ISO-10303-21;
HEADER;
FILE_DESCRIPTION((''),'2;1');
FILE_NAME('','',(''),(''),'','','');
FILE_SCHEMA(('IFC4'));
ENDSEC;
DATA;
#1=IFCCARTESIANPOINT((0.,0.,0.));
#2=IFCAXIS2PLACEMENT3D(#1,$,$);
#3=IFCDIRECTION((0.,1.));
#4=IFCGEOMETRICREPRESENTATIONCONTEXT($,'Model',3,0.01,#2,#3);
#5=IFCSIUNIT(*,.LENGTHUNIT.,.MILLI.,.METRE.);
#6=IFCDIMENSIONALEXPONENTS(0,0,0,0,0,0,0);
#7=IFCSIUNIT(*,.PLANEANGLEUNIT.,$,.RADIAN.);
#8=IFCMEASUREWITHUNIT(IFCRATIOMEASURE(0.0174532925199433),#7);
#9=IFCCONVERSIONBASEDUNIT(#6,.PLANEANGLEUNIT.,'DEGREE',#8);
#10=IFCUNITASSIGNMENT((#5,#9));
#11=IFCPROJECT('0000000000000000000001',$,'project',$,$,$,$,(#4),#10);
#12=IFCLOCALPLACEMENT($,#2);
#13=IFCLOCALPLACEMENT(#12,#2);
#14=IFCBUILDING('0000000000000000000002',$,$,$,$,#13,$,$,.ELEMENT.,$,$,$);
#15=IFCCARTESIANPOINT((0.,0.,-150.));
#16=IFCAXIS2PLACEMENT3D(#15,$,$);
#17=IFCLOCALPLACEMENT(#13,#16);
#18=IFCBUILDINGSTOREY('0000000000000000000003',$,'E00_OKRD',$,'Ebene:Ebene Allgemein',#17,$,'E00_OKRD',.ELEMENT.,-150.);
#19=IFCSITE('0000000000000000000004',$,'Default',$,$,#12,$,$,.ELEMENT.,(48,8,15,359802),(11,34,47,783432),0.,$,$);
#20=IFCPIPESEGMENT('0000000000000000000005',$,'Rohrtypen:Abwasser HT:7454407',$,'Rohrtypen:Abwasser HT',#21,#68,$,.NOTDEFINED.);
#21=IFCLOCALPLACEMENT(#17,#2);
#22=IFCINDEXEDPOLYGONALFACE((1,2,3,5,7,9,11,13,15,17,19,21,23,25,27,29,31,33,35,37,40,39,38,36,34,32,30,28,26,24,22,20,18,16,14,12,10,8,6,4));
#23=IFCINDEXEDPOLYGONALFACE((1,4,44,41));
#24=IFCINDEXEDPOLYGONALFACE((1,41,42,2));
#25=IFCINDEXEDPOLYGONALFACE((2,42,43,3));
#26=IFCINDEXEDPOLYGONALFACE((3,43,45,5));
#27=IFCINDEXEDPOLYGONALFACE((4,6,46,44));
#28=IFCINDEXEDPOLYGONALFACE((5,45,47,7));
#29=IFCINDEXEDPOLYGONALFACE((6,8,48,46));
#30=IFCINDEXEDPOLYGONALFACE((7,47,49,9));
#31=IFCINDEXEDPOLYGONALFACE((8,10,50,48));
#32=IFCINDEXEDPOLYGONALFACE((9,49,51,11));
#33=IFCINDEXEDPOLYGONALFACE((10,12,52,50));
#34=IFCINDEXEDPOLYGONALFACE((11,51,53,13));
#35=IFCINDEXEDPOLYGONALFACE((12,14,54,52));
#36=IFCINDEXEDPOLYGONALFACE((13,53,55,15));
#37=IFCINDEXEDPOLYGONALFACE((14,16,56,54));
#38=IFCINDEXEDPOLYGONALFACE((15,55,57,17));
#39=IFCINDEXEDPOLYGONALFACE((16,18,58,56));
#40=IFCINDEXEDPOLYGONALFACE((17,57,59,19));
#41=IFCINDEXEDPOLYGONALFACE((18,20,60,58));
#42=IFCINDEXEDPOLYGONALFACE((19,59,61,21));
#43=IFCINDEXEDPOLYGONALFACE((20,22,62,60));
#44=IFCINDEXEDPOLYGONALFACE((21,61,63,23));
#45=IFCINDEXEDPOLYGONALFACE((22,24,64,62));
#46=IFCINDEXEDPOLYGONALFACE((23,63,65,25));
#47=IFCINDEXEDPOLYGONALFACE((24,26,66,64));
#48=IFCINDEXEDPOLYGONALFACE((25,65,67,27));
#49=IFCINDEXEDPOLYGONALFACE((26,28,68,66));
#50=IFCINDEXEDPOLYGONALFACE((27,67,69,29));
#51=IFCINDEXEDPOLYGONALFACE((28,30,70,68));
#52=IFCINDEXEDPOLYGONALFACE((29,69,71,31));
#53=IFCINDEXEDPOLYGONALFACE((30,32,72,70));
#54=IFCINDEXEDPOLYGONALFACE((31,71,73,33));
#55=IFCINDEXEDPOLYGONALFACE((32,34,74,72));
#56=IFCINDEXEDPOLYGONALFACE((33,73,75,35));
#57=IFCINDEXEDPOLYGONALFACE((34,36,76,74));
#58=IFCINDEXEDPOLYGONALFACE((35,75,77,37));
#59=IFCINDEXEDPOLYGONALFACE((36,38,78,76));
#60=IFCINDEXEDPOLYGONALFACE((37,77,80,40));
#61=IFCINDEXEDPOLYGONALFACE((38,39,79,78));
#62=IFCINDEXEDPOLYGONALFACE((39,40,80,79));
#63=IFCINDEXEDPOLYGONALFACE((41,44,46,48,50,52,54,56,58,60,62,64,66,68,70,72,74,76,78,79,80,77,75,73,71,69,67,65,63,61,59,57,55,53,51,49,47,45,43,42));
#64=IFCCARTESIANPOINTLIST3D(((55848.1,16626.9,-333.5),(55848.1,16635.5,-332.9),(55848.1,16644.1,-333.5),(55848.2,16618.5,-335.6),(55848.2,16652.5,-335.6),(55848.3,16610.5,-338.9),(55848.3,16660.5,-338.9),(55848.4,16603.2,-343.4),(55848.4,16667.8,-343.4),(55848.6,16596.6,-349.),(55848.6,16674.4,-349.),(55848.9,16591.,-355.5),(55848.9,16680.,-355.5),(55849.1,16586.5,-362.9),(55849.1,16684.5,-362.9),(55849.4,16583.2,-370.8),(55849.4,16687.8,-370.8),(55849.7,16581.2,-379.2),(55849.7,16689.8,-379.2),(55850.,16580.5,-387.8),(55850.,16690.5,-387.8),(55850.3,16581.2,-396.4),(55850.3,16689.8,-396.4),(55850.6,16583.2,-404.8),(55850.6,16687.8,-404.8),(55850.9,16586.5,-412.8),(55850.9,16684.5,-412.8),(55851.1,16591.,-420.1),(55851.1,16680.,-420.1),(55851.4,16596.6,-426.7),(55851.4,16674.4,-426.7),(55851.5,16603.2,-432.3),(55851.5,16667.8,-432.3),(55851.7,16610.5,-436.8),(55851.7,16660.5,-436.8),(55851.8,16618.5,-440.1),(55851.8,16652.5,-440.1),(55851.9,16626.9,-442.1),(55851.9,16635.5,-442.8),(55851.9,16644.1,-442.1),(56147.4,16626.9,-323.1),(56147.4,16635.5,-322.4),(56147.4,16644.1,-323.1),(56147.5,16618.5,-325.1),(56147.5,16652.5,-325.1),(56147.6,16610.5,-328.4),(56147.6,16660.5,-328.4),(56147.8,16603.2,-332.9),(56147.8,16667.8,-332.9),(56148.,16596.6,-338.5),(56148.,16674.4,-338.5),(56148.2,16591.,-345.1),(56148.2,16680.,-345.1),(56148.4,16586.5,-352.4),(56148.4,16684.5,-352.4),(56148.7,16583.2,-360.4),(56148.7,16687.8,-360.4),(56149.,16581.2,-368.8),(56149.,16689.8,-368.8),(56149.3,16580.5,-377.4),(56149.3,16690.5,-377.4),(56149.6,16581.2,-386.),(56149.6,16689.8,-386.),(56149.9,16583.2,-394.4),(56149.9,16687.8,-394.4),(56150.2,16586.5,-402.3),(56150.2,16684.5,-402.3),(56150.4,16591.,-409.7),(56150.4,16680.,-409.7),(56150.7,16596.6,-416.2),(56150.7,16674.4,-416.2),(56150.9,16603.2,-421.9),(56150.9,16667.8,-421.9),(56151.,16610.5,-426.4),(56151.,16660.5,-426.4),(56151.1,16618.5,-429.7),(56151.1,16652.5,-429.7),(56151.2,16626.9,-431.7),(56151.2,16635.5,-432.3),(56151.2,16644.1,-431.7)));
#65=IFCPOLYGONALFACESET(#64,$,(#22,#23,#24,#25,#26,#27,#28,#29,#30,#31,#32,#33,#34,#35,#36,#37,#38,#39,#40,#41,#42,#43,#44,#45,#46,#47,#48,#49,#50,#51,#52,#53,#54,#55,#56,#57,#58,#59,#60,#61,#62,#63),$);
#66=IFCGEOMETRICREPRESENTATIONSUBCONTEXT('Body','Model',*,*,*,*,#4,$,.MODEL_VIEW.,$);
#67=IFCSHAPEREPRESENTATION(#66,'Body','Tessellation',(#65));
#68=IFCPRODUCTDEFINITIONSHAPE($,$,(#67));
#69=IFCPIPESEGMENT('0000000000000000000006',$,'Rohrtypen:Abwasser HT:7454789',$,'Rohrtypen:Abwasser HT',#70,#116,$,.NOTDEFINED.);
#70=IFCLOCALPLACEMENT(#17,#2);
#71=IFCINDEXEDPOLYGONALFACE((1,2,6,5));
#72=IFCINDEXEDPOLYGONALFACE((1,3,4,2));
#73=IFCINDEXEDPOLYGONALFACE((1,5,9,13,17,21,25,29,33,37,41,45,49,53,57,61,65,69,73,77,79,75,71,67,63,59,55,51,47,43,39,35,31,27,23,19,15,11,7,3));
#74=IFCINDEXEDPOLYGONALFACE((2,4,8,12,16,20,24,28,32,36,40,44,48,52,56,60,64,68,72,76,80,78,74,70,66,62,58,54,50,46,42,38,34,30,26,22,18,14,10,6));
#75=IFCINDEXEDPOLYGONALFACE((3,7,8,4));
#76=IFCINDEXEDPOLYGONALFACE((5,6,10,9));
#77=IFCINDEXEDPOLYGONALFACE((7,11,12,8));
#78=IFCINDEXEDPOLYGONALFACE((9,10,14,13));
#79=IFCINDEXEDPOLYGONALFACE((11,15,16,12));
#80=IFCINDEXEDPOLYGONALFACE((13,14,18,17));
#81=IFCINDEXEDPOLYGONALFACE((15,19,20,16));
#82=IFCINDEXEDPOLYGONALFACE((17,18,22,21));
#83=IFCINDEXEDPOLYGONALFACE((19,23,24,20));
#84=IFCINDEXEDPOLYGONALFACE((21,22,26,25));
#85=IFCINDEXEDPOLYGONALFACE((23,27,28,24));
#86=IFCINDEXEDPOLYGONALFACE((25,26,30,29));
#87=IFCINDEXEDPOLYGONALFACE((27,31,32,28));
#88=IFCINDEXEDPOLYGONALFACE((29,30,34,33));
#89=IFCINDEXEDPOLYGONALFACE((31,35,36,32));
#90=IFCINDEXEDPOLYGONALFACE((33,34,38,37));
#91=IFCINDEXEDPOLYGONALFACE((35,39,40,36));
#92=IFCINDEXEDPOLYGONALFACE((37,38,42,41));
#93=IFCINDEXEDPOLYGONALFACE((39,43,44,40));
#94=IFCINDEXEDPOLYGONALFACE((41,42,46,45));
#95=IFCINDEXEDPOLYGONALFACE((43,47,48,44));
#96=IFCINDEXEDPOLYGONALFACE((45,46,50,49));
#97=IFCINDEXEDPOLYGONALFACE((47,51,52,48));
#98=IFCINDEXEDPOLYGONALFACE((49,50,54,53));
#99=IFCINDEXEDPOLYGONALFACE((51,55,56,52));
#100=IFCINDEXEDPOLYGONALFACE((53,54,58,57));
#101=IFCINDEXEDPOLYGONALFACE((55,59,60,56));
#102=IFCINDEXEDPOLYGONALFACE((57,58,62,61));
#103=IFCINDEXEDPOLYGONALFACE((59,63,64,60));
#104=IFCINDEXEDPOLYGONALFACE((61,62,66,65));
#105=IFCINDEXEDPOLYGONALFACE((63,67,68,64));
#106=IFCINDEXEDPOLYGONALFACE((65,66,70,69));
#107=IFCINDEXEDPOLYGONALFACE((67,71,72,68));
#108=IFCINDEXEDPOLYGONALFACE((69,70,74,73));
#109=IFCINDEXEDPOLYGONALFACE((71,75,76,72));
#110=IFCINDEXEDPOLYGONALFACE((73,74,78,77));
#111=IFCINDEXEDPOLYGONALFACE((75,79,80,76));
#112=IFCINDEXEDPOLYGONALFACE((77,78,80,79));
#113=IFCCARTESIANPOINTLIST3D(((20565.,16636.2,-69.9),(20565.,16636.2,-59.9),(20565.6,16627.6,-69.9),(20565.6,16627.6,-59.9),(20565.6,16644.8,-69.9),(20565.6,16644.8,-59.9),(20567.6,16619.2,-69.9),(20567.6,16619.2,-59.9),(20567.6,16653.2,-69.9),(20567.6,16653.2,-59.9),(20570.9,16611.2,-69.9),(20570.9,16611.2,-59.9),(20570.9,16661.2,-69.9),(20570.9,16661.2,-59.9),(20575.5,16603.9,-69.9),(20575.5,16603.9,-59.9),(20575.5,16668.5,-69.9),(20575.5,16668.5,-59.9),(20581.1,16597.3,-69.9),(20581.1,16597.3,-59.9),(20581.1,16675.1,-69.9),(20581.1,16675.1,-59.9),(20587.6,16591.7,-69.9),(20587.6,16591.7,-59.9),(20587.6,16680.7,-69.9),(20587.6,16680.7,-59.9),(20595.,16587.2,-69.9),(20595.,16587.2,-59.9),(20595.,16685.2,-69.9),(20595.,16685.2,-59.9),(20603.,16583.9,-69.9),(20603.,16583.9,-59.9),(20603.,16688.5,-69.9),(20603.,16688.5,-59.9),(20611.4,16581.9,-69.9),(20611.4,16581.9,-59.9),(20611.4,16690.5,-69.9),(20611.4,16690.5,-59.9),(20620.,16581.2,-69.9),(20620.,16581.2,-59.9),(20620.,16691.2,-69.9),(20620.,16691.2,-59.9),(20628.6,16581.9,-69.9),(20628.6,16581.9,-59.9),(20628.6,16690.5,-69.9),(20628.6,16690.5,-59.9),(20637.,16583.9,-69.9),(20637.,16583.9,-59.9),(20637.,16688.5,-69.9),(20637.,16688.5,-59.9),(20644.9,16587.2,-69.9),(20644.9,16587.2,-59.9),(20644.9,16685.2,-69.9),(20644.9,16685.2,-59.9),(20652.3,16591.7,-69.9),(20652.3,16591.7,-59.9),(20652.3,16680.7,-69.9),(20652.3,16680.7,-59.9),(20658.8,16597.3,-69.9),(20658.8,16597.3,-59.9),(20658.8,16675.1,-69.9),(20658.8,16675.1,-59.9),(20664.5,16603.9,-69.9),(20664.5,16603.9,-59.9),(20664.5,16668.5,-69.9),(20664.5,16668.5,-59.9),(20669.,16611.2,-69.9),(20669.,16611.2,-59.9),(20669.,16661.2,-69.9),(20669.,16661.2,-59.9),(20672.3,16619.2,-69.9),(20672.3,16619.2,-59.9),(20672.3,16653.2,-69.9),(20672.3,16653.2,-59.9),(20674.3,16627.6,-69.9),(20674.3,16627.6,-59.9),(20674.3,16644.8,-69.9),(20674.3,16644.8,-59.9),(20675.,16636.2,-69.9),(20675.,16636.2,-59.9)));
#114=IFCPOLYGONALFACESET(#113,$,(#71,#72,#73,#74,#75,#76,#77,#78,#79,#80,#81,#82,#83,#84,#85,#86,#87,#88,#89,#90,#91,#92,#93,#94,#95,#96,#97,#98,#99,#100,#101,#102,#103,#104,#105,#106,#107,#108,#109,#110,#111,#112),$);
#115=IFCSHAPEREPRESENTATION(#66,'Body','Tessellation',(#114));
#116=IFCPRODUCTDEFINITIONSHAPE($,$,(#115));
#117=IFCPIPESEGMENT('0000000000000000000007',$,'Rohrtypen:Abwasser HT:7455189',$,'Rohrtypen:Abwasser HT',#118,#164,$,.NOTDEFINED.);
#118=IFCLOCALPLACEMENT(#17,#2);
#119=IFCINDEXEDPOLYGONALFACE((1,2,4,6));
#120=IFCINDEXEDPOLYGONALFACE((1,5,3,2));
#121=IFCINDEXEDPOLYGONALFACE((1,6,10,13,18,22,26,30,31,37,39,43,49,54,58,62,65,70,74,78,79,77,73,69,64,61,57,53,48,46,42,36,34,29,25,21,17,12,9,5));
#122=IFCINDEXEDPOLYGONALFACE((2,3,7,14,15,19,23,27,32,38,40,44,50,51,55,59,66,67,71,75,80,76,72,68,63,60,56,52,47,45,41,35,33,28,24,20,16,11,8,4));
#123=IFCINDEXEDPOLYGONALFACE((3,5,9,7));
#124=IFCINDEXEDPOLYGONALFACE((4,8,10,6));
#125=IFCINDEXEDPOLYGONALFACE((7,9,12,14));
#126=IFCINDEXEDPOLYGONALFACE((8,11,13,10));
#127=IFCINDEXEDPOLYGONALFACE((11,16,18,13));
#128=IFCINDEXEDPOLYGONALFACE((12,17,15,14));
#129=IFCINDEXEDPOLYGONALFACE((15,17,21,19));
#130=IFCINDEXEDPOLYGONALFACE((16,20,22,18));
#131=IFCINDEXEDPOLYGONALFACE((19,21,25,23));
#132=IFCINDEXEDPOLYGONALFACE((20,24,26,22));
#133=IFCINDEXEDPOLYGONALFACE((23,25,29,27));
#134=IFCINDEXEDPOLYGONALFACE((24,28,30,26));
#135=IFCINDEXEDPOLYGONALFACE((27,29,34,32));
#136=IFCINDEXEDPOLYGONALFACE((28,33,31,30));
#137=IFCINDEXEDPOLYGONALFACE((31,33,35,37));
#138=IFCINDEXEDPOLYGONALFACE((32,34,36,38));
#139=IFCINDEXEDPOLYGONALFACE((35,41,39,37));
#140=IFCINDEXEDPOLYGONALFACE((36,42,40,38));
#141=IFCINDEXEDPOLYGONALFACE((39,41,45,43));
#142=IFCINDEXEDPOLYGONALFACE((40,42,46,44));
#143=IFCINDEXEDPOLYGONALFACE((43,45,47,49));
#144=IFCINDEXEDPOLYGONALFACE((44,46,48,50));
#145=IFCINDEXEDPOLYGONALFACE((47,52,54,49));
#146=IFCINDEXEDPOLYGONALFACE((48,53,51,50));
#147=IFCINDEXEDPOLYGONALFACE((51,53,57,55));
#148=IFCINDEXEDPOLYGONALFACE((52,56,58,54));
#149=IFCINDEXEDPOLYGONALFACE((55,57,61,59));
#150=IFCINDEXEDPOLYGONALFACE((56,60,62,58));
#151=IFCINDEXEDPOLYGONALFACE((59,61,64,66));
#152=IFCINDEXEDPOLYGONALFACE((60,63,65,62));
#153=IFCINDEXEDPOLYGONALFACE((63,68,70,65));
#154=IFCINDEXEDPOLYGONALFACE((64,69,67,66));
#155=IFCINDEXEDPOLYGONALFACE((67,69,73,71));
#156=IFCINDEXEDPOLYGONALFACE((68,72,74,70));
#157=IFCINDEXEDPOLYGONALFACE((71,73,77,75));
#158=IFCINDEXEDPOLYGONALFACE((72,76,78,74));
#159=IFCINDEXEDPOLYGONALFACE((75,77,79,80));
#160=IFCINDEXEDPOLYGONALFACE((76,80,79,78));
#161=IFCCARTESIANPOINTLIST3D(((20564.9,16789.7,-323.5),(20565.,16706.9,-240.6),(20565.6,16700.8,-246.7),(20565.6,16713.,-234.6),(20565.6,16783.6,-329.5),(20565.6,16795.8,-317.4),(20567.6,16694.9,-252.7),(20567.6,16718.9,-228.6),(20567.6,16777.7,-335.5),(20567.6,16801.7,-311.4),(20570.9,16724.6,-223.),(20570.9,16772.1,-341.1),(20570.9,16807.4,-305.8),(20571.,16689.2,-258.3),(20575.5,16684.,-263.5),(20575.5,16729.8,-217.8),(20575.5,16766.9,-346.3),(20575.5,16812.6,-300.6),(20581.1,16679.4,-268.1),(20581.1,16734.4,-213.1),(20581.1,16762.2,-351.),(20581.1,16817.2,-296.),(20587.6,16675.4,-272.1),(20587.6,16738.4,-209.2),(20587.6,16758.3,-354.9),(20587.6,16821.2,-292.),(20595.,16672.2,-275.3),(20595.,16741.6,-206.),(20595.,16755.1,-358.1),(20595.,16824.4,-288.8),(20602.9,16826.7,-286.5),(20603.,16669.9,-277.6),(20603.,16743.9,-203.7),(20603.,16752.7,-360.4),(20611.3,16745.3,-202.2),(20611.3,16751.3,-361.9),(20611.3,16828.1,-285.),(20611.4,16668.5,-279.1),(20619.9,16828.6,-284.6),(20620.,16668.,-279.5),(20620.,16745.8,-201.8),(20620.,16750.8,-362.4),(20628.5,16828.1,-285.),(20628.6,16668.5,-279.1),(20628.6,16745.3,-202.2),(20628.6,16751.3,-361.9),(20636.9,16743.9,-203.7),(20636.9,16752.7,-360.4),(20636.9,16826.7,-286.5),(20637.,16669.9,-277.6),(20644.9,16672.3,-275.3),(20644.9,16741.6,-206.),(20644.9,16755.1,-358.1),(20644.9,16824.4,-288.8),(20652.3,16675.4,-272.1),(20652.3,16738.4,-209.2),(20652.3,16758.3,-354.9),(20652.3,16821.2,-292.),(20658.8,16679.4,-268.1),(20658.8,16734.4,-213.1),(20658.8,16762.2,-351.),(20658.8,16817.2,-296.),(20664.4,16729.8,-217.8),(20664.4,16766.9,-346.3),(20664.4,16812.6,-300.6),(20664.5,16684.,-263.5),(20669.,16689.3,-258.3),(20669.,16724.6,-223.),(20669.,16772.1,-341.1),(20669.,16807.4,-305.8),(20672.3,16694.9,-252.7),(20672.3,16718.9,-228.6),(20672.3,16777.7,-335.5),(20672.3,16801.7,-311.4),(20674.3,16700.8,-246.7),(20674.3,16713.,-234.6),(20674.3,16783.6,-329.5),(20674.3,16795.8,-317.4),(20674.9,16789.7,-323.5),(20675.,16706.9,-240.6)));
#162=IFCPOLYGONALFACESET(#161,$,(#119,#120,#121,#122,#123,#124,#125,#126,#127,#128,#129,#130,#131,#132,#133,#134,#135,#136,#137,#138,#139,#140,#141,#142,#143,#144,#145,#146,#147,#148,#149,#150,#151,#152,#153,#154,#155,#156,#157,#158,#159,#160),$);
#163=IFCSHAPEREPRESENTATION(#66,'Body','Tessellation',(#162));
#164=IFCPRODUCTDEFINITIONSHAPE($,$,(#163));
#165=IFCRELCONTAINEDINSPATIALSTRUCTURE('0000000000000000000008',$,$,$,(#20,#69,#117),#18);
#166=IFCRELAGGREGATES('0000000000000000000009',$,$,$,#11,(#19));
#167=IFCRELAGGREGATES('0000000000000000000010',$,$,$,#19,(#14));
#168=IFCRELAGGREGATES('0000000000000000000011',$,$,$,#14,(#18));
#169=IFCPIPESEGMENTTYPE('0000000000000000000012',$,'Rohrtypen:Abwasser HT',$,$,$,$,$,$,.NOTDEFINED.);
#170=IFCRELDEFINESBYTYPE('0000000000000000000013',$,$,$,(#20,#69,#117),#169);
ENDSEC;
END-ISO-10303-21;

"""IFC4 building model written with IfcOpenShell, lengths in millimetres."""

from ifc_helpers import new_model, entity, si_unit, converted_unit, direction, frame, origin, place, context, subcontext, project, spatial, indexed_curve, outline, extrude, type_object, element, save


model = new_model("IFC4")

# Units and contexts
model_context = context("Model", 3, precision=0.01, world=origin(), true_north=direction((0.0, 1.0)))
body_context = subcontext(model_context, "Body", "Model", "MODEL_VIEW")
ifc_project = project(units=[si_unit("LENGTHUNIT", "METRE", prefix="MILLI"), converted_unit("PLANEANGLEUNIT", "DEGREE", entity("IfcRatioMeasure", 0.0174532925199433), si_unit("PLANEANGLEUNIT", "RADIAN"), dimensions=[0, 0, 0, 0, 0, 0, 0])], contexts=[model_context])

# Site, building, storey
site_placement = place(None, origin())
site = spatial("IfcSite", under=ifc_project, at=site_placement, Name="Default", CompositionType="ELEMENT", RefLatitude=(48, 8, 15, 359802), RefLongitude=(11, 34, 47, 783432), RefElevation=0.0)
building_placement = place(site_placement, origin())
building = spatial("IfcBuilding", under=site, at=building_placement, CompositionType="ELEMENT")
storey_placement = place(building_placement, frame((0.0, 0.0, -150.0)))
storey = spatial("IfcBuildingStorey", under=building, at=storey_placement, Name="E00_OKRD", ObjectType="Ebene:Ebene Allgemein", LongName="E00_OKRD", CompositionType="ELEMENT", Elevation=-150.0)

# Pipe segments
pipe_segment_type_1 = type_object("IfcPipeSegmentType", Name="Rohrtypen:Abwasser HT", PredefinedType="NOTDEFINED")
pipe_segment_1_placement = place(storey_placement, origin())
element("IfcPipeSegment", 1, at=pipe_segment_1_placement, inside=storey, type_object=pipe_segment_type_1, Name="Rohrtypen:Abwasser HT:7454407", ObjectType="Rohrtypen:Abwasser HT", PredefinedType="NOTDEFINED", context=body_context, shape_type="SweptSolid", body=[
    extrude(outline(indexed_curve([(55.0, 0.0), (54.3, 8.6), (52.3, 17.0), (49.0, 25.0), (44.5, 32.3), (38.9, 38.9), (32.3, 44.5), (25.0, 49.0), (17.0, 52.3), (8.6, 54.3), (0.0, 55.0), (-8.6, 54.3), (-17.0, 52.3), (-25.0, 49.0), (-32.3, 44.5), (-38.9, 38.9), (-44.5, 32.3), (-49.0, 25.0), (-52.3, 17.0), (-54.3, 8.6), (-55.0, 0.0), (-54.3, -8.6), (-52.3, -17.0), (-49.0, -25.0), (-44.5, -32.3), (-38.9, -38.9), (-32.3, -44.5), (-25.0, -49.0), (-17.0, -52.3), (-8.6, -54.3), (0.0, -55.0), (8.6, -54.3), (17.0, -52.3), (25.0, -49.0), (32.3, -44.5), (38.9, -38.9), (44.5, -32.3), (49.0, -25.0), (52.3, -17.0), (54.3, -8.6), (55.0, 0.0)], self_intersect=False)), frame((55850.0, 16635.5, -387.8), z_axis=(0.999391, 0.0, 0.034899), x_axis=(0.0, 1.0, 0.0)), (0.0, 0.0, 1.0), 299.5),
])
pipe_segment_2_placement = place(storey_placement, origin())
element("IfcPipeSegment", 2, at=pipe_segment_2_placement, inside=storey, type_object=pipe_segment_type_1, Name="Rohrtypen:Abwasser HT:7454789", ObjectType="Rohrtypen:Abwasser HT", PredefinedType="NOTDEFINED", context=body_context, shape_type="SweptSolid", body=[
    extrude(outline(indexed_curve([(55.0, 0.0), (54.3, 8.6), (52.3, 17.0), (49.0, 25.0), (44.5, 32.3), (38.9, 38.9), (32.3, 44.5), (25.0, 49.0), (17.0, 52.3), (8.6, 54.3), (0.0, 55.0), (-8.6, 54.3), (-17.0, 52.3), (-25.0, 49.0), (-32.3, 44.5), (-38.9, 38.9), (-44.5, 32.3), (-49.0, 25.0), (-52.3, 17.0), (-54.3, 8.6), (-55.0, 0.0), (-54.3, -8.6), (-52.3, -17.0), (-49.0, -25.0), (-44.5, -32.3), (-38.9, -38.9), (-32.3, -44.5), (-25.0, -49.0), (-17.0, -52.3), (-8.6, -54.3), (0.0, -55.0), (8.6, -54.3), (17.0, -52.3), (25.0, -49.0), (32.3, -44.5), (38.9, -38.9), (44.5, -32.3), (49.0, -25.0), (52.3, -17.0), (54.3, -8.6), (55.0, 0.0)], self_intersect=False)), frame((20620.0, 16636.2, -69.9)), (0.0, 0.0, 1.0), 10.0),
])
pipe_segment_3_placement = place(storey_placement, origin())
element("IfcPipeSegment", 3, at=pipe_segment_3_placement, inside=storey, type_object=pipe_segment_type_1, Name="Rohrtypen:Abwasser HT:7455189", ObjectType="Rohrtypen:Abwasser HT", PredefinedType="NOTDEFINED", context=body_context, shape_type="SweptSolid", body=[
    extrude(outline(indexed_curve([(55.0, 0.0), (54.3, 8.6), (52.3, 17.0), (49.0, 25.0), (44.5, 32.3), (38.9, 38.9), (32.3, 44.5), (25.0, 49.0), (17.0, 52.3), (8.6, 54.3), (0.0, 55.0), (-8.6, 54.3), (-17.0, 52.3), (-25.0, 49.0), (-32.3, 44.5), (-38.9, 38.9), (-44.5, 32.3), (-49.0, 25.0), (-52.3, 17.0), (-54.3, 8.6), (-55.0, 0.0), (-54.3, -8.6), (-52.3, -17.0), (-49.0, -25.0), (-44.5, -32.3), (-38.9, -38.9), (-32.3, -44.5), (-25.0, -49.0), (-17.0, -52.3), (-8.6, -54.3), (0.0, -55.0), (8.6, -54.3), (17.0, -52.3), (25.0, -49.0), (32.3, -44.5), (38.9, -38.9), (44.5, -32.3), (49.0, -25.0), (52.3, -17.0), (54.3, -8.6), (55.0, 0.0)], self_intersect=False)), frame((20619.9, 16789.7, -323.5), z_axis=(0.000058, -0.707107, 0.707107), x_axis=(1.0, 0.000083, 0.0)), (0.0, 0.0, 1.0), 117.1),
])

save(model, "model.ifc")
